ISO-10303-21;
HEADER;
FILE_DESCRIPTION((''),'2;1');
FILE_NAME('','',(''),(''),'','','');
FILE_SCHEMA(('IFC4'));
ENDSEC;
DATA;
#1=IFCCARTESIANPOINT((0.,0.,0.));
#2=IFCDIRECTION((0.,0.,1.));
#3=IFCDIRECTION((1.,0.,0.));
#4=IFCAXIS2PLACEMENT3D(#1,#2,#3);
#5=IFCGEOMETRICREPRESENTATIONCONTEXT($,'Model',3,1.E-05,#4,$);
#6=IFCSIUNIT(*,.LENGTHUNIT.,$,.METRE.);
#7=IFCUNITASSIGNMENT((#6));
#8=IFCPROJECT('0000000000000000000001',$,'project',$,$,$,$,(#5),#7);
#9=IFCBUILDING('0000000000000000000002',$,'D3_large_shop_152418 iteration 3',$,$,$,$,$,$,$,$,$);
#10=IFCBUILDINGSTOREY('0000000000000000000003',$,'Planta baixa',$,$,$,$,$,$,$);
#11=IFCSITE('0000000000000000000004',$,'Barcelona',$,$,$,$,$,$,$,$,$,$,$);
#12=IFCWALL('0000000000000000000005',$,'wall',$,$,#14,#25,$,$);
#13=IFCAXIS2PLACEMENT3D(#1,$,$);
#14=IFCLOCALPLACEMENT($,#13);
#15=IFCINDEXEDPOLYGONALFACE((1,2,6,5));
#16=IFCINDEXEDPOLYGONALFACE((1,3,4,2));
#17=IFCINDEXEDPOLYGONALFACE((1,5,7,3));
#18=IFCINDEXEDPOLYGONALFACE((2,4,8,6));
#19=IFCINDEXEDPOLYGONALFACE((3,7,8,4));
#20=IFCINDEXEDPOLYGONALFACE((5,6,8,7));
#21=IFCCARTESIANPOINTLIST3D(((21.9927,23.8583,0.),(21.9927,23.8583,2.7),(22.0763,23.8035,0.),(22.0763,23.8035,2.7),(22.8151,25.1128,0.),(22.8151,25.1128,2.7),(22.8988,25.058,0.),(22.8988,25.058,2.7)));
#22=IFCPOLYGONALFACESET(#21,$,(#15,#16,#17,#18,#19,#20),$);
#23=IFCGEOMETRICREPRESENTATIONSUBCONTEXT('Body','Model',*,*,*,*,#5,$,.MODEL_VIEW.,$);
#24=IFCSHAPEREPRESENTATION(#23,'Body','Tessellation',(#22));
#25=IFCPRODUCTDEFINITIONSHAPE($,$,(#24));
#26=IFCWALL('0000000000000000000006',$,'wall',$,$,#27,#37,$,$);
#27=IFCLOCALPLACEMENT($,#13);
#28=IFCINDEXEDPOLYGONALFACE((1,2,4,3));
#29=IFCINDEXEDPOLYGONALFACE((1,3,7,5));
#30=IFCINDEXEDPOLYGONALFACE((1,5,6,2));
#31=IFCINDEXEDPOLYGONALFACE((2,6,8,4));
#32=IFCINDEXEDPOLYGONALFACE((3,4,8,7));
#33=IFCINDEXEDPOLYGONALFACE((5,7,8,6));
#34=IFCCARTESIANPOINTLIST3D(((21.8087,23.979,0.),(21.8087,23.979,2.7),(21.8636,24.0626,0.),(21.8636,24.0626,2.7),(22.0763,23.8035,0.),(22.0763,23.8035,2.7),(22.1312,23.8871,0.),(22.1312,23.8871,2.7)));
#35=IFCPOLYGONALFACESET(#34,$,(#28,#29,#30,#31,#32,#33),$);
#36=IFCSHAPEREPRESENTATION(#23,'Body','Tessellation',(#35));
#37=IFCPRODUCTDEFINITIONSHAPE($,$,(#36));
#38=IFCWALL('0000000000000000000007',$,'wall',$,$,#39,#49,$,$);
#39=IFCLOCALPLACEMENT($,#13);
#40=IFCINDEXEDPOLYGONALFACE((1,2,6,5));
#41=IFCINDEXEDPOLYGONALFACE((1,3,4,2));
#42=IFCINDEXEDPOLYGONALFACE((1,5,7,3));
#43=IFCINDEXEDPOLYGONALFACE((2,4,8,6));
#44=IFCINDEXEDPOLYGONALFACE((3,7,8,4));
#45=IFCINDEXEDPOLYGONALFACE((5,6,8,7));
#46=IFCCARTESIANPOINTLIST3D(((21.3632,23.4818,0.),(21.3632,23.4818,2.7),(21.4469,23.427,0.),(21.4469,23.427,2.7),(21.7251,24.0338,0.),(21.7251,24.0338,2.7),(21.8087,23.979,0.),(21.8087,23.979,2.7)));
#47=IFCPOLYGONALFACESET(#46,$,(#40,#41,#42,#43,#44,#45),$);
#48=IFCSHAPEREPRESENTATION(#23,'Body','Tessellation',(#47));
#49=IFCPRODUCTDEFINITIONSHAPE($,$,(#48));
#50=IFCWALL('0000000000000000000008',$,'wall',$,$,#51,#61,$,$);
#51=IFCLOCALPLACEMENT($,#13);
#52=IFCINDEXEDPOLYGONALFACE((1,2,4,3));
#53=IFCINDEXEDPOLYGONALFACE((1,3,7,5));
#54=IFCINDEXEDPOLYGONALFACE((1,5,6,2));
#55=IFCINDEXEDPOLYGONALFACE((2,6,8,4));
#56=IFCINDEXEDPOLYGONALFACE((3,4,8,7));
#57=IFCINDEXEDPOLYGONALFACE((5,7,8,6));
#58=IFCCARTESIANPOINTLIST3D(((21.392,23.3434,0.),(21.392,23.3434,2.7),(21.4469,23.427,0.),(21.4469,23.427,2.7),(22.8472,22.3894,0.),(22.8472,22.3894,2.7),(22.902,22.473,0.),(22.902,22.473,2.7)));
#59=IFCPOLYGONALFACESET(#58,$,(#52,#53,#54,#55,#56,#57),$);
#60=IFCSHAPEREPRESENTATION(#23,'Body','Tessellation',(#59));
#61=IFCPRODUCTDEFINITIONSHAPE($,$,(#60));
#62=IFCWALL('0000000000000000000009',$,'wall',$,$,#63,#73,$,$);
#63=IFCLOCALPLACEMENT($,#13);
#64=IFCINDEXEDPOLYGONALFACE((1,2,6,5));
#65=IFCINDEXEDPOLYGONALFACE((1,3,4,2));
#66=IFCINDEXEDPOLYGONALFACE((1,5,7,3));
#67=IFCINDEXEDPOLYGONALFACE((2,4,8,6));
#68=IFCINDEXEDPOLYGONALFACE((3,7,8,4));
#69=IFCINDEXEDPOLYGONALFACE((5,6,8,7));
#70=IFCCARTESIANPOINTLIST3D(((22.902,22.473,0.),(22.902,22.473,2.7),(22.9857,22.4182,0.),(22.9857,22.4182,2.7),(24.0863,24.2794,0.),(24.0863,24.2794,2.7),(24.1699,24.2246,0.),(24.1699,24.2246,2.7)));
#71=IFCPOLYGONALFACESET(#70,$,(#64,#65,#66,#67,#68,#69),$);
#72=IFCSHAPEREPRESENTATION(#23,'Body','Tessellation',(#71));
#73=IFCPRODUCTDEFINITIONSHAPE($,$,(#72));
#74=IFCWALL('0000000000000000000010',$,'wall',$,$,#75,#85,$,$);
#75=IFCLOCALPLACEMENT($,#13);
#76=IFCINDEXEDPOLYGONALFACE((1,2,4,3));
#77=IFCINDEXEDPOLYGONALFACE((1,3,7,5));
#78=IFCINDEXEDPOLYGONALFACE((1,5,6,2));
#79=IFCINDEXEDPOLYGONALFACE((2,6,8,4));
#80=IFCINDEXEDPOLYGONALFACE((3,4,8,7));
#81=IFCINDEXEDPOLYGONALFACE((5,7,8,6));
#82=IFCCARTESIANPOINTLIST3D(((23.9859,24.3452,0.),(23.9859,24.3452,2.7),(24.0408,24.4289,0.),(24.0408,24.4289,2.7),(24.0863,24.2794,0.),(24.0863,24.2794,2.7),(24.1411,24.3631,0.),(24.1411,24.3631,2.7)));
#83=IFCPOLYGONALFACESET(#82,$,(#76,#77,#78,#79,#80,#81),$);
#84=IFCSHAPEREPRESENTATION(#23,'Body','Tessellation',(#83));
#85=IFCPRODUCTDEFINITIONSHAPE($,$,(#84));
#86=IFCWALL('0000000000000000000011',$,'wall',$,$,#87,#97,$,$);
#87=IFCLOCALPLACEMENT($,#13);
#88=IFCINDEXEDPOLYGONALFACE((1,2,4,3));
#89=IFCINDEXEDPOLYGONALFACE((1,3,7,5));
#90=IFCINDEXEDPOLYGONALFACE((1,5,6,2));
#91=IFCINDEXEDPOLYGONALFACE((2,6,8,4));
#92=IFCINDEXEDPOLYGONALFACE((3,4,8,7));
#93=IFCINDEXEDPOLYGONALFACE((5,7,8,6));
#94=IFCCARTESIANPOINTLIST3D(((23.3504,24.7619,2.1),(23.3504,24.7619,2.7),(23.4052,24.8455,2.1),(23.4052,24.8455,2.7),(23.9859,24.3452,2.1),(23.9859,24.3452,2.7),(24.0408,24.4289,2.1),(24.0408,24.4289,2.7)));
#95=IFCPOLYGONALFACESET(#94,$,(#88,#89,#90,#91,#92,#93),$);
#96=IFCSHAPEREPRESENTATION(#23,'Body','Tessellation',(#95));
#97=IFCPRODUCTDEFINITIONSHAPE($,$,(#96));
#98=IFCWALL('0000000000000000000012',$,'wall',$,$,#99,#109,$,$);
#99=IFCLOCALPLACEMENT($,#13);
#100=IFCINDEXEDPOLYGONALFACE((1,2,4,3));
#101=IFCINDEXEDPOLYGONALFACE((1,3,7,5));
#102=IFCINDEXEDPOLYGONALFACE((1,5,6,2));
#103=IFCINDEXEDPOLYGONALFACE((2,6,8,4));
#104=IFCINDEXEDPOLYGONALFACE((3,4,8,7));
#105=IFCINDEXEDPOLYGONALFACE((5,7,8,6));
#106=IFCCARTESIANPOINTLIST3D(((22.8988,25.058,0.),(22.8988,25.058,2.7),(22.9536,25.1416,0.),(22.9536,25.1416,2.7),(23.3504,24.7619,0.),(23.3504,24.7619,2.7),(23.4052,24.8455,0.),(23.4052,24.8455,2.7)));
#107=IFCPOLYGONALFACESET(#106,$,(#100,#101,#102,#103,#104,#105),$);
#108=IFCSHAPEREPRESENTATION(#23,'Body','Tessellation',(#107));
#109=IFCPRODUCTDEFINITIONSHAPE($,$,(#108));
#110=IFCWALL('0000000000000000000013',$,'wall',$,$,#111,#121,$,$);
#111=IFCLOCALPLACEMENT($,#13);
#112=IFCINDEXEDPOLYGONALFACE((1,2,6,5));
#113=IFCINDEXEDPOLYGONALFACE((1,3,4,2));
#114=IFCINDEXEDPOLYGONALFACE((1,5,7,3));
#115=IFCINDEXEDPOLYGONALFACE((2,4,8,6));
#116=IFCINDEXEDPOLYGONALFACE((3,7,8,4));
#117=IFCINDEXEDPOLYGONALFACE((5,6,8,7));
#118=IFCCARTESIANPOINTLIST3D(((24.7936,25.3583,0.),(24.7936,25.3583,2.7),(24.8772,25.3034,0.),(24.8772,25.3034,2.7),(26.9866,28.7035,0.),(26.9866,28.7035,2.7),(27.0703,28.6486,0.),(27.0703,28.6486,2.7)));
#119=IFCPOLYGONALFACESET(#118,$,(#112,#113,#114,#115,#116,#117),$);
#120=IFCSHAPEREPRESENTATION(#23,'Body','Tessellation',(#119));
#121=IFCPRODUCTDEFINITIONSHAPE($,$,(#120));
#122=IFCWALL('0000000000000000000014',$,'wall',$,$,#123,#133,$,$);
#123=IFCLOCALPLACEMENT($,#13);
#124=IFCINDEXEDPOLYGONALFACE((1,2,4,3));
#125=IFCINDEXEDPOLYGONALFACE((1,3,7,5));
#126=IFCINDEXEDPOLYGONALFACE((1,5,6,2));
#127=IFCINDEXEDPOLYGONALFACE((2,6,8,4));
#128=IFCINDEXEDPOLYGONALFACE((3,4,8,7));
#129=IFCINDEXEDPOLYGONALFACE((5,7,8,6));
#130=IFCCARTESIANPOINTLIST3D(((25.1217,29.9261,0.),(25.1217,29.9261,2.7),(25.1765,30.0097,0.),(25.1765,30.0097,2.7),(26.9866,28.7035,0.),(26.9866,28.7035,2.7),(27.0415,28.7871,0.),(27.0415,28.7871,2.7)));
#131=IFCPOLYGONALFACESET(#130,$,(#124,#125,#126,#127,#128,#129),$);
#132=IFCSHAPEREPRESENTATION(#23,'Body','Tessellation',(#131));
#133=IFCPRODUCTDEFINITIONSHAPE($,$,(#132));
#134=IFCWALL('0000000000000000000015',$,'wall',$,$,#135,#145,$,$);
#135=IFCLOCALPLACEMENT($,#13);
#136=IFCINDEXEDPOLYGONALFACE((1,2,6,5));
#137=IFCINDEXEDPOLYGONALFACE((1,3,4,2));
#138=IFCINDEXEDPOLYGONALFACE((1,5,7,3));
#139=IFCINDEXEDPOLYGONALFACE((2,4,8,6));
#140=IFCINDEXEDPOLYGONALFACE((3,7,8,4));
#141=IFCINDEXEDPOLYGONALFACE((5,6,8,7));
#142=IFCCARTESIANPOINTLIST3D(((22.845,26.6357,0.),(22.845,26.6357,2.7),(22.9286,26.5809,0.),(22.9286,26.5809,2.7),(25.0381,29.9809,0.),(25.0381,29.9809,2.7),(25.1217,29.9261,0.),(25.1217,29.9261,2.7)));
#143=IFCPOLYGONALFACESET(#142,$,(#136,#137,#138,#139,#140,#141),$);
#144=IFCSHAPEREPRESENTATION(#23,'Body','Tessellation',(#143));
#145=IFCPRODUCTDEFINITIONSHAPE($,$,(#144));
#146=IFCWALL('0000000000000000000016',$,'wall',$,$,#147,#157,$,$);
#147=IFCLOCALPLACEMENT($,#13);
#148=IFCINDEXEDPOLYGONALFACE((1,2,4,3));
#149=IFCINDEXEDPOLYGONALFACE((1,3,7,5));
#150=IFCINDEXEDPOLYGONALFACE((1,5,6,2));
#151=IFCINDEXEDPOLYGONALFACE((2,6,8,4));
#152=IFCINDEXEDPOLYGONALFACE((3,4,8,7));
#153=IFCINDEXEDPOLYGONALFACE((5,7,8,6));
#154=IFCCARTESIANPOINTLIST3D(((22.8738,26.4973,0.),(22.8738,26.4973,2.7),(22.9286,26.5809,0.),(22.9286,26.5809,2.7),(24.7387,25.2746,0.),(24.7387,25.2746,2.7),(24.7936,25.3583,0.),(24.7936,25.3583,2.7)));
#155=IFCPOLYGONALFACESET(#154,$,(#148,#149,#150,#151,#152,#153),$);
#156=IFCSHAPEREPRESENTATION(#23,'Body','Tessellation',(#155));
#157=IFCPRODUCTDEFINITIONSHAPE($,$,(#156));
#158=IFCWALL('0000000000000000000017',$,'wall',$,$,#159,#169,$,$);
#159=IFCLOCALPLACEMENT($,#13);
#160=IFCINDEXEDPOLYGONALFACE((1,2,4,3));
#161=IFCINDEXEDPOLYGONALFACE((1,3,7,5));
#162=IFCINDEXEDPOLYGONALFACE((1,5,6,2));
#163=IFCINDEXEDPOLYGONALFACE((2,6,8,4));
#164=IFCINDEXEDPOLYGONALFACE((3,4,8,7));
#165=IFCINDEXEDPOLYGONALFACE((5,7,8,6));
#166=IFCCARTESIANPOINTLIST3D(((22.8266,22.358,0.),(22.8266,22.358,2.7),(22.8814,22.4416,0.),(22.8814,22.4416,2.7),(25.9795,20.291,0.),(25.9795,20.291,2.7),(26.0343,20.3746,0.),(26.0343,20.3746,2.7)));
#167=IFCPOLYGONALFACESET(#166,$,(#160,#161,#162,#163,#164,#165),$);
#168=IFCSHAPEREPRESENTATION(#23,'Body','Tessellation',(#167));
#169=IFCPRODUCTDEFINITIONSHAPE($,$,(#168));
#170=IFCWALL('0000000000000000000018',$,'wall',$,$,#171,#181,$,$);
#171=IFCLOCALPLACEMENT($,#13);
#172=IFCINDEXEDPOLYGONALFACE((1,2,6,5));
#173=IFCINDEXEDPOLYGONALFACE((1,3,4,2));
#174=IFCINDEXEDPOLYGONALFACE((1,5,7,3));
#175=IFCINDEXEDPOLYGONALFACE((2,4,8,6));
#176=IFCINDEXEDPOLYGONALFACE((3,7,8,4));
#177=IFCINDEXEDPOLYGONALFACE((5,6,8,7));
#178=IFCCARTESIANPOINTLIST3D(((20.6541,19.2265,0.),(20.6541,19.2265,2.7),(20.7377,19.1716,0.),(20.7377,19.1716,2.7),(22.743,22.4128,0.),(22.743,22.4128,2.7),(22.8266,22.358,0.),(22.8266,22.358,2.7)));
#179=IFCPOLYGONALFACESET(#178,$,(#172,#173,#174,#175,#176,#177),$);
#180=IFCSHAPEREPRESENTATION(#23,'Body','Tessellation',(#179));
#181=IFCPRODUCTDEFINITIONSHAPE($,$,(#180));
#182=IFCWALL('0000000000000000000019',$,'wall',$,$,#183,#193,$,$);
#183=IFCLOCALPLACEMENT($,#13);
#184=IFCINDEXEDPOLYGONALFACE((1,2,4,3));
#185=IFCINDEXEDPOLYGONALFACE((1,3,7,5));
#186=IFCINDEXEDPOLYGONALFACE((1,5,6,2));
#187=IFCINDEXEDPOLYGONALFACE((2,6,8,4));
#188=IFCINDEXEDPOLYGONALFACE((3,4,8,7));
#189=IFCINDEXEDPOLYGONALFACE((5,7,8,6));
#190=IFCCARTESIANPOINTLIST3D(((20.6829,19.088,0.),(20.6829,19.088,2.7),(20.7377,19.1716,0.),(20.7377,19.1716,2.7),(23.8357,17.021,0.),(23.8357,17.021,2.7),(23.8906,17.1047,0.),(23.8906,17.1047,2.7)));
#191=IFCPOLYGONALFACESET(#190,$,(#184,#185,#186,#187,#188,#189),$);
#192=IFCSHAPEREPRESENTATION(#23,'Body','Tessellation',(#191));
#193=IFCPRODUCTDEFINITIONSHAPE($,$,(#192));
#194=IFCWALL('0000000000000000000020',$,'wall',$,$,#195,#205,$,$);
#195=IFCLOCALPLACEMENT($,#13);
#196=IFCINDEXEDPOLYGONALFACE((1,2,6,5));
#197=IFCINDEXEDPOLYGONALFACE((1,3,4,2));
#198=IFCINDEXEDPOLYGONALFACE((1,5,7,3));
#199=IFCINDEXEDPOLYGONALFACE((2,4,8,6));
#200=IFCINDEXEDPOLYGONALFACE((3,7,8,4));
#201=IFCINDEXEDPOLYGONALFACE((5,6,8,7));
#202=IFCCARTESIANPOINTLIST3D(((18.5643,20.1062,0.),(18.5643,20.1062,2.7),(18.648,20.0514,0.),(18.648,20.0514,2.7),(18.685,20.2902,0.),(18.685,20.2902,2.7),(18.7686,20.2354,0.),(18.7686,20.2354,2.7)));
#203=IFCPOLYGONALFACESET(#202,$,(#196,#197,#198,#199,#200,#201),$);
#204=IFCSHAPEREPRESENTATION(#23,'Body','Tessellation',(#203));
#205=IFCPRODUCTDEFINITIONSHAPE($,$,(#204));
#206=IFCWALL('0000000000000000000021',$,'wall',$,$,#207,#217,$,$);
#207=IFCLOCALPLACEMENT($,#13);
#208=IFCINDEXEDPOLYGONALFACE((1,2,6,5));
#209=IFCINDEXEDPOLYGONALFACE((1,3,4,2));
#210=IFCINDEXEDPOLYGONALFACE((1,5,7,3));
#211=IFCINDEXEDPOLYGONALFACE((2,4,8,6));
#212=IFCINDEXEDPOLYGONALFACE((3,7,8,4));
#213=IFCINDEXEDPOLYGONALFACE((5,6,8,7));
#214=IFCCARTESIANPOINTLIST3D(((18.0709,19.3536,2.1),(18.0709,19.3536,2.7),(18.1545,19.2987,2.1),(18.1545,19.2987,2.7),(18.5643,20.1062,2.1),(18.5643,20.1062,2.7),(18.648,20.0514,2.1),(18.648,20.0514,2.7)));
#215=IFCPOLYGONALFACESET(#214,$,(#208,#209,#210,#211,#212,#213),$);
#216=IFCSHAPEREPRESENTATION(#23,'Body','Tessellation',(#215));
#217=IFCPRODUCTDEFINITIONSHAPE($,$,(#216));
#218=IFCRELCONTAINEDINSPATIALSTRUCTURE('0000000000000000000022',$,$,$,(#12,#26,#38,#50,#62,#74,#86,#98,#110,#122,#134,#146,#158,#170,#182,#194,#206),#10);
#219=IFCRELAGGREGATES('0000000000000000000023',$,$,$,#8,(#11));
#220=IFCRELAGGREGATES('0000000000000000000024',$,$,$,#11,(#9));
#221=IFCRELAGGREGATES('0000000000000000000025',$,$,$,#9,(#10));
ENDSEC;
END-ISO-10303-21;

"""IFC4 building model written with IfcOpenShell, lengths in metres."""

from ifc_helpers import new_model, si_unit, frame, origin, origin_with_axes, place, context, subcontext, project, spatial, polyline, outline, extrude, element, save


model = new_model("IFC4")

# Units and contexts
model_context = context("Model", 3, precision=1e-05, world=origin_with_axes())
body_context = subcontext(model_context, "Body", "Model", "MODEL_VIEW")
ifc_project = project(units=[si_unit("LENGTHUNIT", "METRE")], contexts=[model_context])

# Site, building, storey
site = spatial("IfcSite", under=ifc_project, Name="Barcelona")
building = spatial("IfcBuilding", under=site, Name="D3_large_shop_152418 iteration 3")
storey = spatial("IfcBuildingStorey", under=building, Name="Planta baixa")

# Walls
wall_1_placement = place(None, origin_with_axes())
element("IfcWall", 1, at=wall_1_placement, inside=storey, Name="wall", context=body_context, shape_type="SweptSolid", body=[
    extrude(outline(polyline([(22.8988, 25.058), (22.0763, 23.8035), (21.9927, 23.8583), (22.8151, 25.1128), (22.8988, 25.058)])), origin(), (0.0, 0.0, 1.0), 2.7),
])
wall_2_placement = place(None, origin_with_axes())
element("IfcWall", 2, at=wall_2_placement, inside=storey, Name="wall", context=body_context, shape_type="SweptSolid", body=[
    extrude(outline(polyline([(22.0763, 23.8035), (21.8087, 23.979), (21.8636, 24.0626), (22.1312, 23.8871), (22.0763, 23.8035)])), origin(), (0.0, 0.0, 1.0), 2.7),
])
wall_3_placement = place(None, origin_with_axes())
element("IfcWall", 3, at=wall_3_placement, inside=storey, Name="wall", context=body_context, shape_type="SweptSolid", body=[
    extrude(outline(polyline([(21.8087, 23.979), (21.4469, 23.427), (21.3632, 23.4818), (21.7251, 24.0338), (21.8087, 23.979)])), origin(), (0.0, 0.0, 1.0), 2.7),
])
wall_4_placement = place(None, origin_with_axes())
element("IfcWall", 4, at=wall_4_placement, inside=storey, Name="wall", context=body_context, shape_type="SweptSolid", body=[
    extrude(outline(polyline([(21.4469, 23.427), (22.902, 22.473), (22.8472, 22.3894), (21.392, 23.3434), (21.4469, 23.427)])), origin(), (0.0, 0.0, 1.0), 2.7),
])
wall_5_placement = place(None, origin_with_axes())
element("IfcWall", 5, at=wall_5_placement, inside=storey, Name="wall", context=body_context, shape_type="SweptSolid", body=[
    extrude(outline(polyline([(22.902, 22.473), (24.0863, 24.2794), (24.1699, 24.2246), (22.9857, 22.4182), (22.902, 22.473)])), origin(), (0.0, 0.0, 1.0), 2.7),
])
wall_6_placement = place(None, origin_with_axes())
element("IfcWall", 6, at=wall_6_placement, inside=storey, Name="wall", context=body_context, shape_type="SweptSolid", body=[
    extrude(outline(polyline([(24.0863, 24.2794), (23.9859, 24.3452), (24.0408, 24.4289), (24.1411, 24.3631), (24.0863, 24.2794)])), origin(), (0.0, 0.0, 1.0), 2.7),
])
wall_7_placement = place(None, origin_with_axes())
element("IfcWall", 7, at=wall_7_placement, inside=storey, Name="wall", context=body_context, shape_type="SweptSolid", body=[
    extrude(outline(polyline([(23.9859, 24.3452), (23.3504, 24.7619), (23.4052, 24.8455), (24.0408, 24.4289), (23.9859, 24.3452)])), frame((0.0, 0.0, 2.1)), (0.0, 0.0, 1.0), 0.6),
])
wall_8_placement = place(None, origin_with_axes())
element("IfcWall", 8, at=wall_8_placement, inside=storey, Name="wall", context=body_context, shape_type="SweptSolid", body=[
    extrude(outline(polyline([(23.3504, 24.7619), (22.8988, 25.058), (22.9536, 25.1416), (23.4052, 24.8455), (23.3504, 24.7619)])), origin(), (0.0, 0.0, 1.0), 2.7),
])
wall_9_placement = place(None, origin_with_axes())
element("IfcWall", 9, at=wall_9_placement, inside=storey, Name="wall", context=body_context, shape_type="SweptSolid", body=[
    extrude(outline(polyline([(24.7936, 25.3583), (26.9866, 28.7035), (27.0703, 28.6486), (24.8772, 25.3034), (24.7936, 25.3583)])), origin(), (0.0, 0.0, 1.0), 2.7),
])
wall_10_placement = place(None, origin_with_axes())
element("IfcWall", 10, at=wall_10_placement, inside=storey, Name="wall", context=body_context, shape_type="SweptSolid", body=[
    extrude(outline(polyline([(26.9866, 28.7035), (25.1217, 29.9261), (25.1765, 30.0097), (27.0415, 28.7871), (26.9866, 28.7035)])), origin(), (0.0, 0.0, 1.0), 2.7),
])
wall_11_placement = place(None, origin_with_axes())
element("IfcWall", 11, at=wall_11_placement, inside=storey, Name="wall", context=body_context, shape_type="SweptSolid", body=[
    extrude(outline(polyline([(25.1217, 29.9261), (22.9286, 26.5809), (22.845, 26.6357), (25.0381, 29.9809), (25.1217, 29.9261)])), origin(), (0.0, 0.0, 1.0), 2.7),
])
wall_12_placement = place(None, origin_with_axes())
element("IfcWall", 12, at=wall_12_placement, inside=storey, Name="wall", context=body_context, shape_type="SweptSolid", body=[
    extrude(outline(polyline([(22.9286, 26.5809), (24.7936, 25.3583), (24.7387, 25.2746), (22.8738, 26.4973), (22.9286, 26.5809)])), origin(), (0.0, 0.0, 1.0), 2.7),
])
wall_13_placement = place(None, origin_with_axes())
element("IfcWall", 13, at=wall_13_placement, inside=storey, Name="wall", context=body_context, shape_type="SweptSolid", body=[
    extrude(outline(polyline([(25.9795, 20.291), (22.8266, 22.358), (22.8814, 22.4416), (26.0343, 20.3746), (25.9795, 20.291)])), origin(), (0.0, 0.0, 1.0), 2.7),
])
wall_14_placement = place(None, origin_with_axes())
element("IfcWall", 14, at=wall_14_placement, inside=storey, Name="wall", context=body_context, shape_type="SweptSolid", body=[
    extrude(outline(polyline([(22.8266, 22.358), (20.7377, 19.1716), (20.6541, 19.2265), (22.743, 22.4128), (22.8266, 22.358)])), origin(), (0.0, 0.0, 1.0), 2.7),
])
wall_15_placement = place(None, origin_with_axes())
element("IfcWall", 15, at=wall_15_placement, inside=storey, Name="wall", context=body_context, shape_type="SweptSolid", body=[
    extrude(outline(polyline([(20.7377, 19.1716), (23.8906, 17.1047), (23.8357, 17.021), (20.6829, 19.088), (20.7377, 19.1716)])), origin(), (0.0, 0.0, 1.0), 2.7),
])
wall_16_placement = place(None, origin_with_axes())
element("IfcWall", 16, at=wall_16_placement, inside=storey, Name="wall", context=body_context, shape_type="SweptSolid", body=[
    extrude(outline(polyline([(18.7686, 20.2354), (18.648, 20.0514), (18.5643, 20.1062), (18.685, 20.2902), (18.7686, 20.2354)])), origin(), (0.0, 0.0, 1.0), 2.7),
])
wall_17_placement = place(None, origin_with_axes())
element("IfcWall", 17, at=wall_17_placement, inside=storey, Name="wall", context=body_context, shape_type="SweptSolid", body=[
    extrude(outline(polyline([(18.648, 20.0514), (18.1545, 19.2987), (18.0709, 19.3536), (18.5643, 20.1062), (18.648, 20.0514)])), frame((0.0, 0.0, 2.1)), (0.0, 0.0, 1.0), 0.6),
])

save(model, "model.ifc")
